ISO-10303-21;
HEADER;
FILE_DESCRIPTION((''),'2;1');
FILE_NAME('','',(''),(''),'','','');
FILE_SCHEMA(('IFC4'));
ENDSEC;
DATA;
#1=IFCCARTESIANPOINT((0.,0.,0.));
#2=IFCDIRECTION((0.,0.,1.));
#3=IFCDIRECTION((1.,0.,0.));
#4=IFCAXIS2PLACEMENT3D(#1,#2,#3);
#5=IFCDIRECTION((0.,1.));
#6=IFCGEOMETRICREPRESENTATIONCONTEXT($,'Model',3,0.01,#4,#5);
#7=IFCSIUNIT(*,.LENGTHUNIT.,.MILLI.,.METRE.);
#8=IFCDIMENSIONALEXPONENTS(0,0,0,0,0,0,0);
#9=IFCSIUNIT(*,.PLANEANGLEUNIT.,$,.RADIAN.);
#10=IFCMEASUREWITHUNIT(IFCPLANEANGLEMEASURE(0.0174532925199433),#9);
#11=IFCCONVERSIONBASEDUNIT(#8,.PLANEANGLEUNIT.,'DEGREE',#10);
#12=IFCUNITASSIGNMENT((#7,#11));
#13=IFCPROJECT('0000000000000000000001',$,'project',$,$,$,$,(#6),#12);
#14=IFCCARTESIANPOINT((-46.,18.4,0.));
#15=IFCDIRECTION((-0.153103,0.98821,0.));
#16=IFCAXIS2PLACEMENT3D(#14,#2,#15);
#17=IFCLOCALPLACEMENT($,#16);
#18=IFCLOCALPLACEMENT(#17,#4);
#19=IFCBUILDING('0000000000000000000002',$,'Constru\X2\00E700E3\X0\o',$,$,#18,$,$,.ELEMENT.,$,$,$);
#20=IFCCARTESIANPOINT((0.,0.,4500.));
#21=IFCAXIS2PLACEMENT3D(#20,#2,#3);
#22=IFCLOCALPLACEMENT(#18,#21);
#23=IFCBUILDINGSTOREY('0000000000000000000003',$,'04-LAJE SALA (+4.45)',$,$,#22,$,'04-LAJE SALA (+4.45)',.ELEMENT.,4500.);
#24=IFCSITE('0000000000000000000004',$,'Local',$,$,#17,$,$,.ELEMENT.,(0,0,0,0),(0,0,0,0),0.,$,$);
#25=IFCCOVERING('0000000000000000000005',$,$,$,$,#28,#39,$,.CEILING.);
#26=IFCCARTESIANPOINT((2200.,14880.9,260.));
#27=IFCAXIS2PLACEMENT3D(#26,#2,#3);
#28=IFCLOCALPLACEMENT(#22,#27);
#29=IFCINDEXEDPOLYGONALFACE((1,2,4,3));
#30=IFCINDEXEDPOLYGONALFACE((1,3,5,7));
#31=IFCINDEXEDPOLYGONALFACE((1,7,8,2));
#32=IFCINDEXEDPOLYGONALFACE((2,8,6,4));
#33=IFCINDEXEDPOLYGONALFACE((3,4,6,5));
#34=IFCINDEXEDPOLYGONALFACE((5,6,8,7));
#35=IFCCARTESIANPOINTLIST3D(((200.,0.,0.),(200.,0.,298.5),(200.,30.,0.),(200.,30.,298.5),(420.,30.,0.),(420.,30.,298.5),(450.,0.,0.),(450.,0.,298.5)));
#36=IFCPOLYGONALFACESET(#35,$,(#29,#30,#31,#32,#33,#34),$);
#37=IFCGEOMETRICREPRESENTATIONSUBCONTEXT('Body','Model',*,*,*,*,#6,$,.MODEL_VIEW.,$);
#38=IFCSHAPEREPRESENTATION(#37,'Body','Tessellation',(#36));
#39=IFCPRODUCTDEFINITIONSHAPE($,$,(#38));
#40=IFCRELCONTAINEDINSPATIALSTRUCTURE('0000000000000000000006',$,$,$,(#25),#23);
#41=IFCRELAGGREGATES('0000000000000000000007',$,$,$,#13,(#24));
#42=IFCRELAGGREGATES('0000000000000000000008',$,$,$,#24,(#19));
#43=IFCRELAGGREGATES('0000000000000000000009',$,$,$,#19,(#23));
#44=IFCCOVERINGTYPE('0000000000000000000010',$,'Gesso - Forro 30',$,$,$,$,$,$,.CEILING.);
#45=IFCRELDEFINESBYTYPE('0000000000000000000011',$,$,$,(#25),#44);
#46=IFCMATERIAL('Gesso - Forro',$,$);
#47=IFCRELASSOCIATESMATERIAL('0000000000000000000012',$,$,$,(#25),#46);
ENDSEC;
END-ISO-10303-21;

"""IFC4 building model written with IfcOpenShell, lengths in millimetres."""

from ifc_helpers import new_model, entity, si_unit, converted_unit, direction, frame, origin_with_axes, place, context, subcontext, project, spatial, line, indexed_curve, outline, extrude, material, type_object, element, save


model = new_model("IFC4")

# Units and contexts
model_context = context("Model", 3, precision=0.01, world=origin_with_axes(), true_north=direction((0.0, 1.0)))
body_context = subcontext(model_context, "Body", "Model", "MODEL_VIEW")
ifc_project = project(units=[si_unit("LENGTHUNIT", "METRE", prefix="MILLI"), converted_unit("PLANEANGLEUNIT", "DEGREE", entity("IfcPlaneAngleMeasure", 0.0174532925199433), si_unit("PLANEANGLEUNIT", "RADIAN"), dimensions=[0, 0, 0, 0, 0, 0, 0])], contexts=[model_context])

# Site, building, storey
site_placement = place(None, frame((-46.0, 18.4, 0.0), z_axis=(0.0, 0.0, 1.0), x_axis=(-0.153103, 0.98821, 0.0)))
site = spatial("IfcSite", under=ifc_project, at=site_placement, Name="Local", CompositionType="ELEMENT", RefLatitude=(0, 0, 0, 0), RefLongitude=(0, 0, 0, 0), RefElevation=0.0)
building_placement = place(site_placement, origin_with_axes())
building = spatial("IfcBuilding", under=site, at=building_placement, Name="Construção", CompositionType="ELEMENT")
storey_placement = place(building_placement, frame((0.0, 0.0, 4500.0), z_axis=(0.0, 0.0, 1.0), x_axis=(1.0, 0.0, 0.0)))
storey = spatial("IfcBuildingStorey", under=building, at=storey_placement, Name="04-LAJE SALA (+4.45)", LongName="04-LAJE SALA (+4.45)", CompositionType="ELEMENT", Elevation=4500.0)

# Covering
ifc_material = material(Name="Gesso - Forro")
covering_type = type_object("IfcCoveringType", Name="Gesso - Forro 30", PredefinedType="CEILING")
covering_1_placement = place(storey_placement, frame((2200.0, 14880.9, 260.0), z_axis=(0.0, 0.0, 1.0), x_axis=(1.0, 0.0, 0.0)))
element("IfcCovering", 1, at=covering_1_placement, inside=storey, type_object=covering_type, material=ifc_material, PredefinedType="CEILING", context=body_context, shape_type="SweptSolid", body=[
    extrude(outline(indexed_curve([(200.0, 0.0), (450.0, 0.0), (420.0, 30.0), (200.0, 30.0)], segments=[line(1, 2, 3, 4, 1)])), origin_with_axes(), (0.0, 0.0, 1.0), 298.5),
])

save(model, "model.ifc")
